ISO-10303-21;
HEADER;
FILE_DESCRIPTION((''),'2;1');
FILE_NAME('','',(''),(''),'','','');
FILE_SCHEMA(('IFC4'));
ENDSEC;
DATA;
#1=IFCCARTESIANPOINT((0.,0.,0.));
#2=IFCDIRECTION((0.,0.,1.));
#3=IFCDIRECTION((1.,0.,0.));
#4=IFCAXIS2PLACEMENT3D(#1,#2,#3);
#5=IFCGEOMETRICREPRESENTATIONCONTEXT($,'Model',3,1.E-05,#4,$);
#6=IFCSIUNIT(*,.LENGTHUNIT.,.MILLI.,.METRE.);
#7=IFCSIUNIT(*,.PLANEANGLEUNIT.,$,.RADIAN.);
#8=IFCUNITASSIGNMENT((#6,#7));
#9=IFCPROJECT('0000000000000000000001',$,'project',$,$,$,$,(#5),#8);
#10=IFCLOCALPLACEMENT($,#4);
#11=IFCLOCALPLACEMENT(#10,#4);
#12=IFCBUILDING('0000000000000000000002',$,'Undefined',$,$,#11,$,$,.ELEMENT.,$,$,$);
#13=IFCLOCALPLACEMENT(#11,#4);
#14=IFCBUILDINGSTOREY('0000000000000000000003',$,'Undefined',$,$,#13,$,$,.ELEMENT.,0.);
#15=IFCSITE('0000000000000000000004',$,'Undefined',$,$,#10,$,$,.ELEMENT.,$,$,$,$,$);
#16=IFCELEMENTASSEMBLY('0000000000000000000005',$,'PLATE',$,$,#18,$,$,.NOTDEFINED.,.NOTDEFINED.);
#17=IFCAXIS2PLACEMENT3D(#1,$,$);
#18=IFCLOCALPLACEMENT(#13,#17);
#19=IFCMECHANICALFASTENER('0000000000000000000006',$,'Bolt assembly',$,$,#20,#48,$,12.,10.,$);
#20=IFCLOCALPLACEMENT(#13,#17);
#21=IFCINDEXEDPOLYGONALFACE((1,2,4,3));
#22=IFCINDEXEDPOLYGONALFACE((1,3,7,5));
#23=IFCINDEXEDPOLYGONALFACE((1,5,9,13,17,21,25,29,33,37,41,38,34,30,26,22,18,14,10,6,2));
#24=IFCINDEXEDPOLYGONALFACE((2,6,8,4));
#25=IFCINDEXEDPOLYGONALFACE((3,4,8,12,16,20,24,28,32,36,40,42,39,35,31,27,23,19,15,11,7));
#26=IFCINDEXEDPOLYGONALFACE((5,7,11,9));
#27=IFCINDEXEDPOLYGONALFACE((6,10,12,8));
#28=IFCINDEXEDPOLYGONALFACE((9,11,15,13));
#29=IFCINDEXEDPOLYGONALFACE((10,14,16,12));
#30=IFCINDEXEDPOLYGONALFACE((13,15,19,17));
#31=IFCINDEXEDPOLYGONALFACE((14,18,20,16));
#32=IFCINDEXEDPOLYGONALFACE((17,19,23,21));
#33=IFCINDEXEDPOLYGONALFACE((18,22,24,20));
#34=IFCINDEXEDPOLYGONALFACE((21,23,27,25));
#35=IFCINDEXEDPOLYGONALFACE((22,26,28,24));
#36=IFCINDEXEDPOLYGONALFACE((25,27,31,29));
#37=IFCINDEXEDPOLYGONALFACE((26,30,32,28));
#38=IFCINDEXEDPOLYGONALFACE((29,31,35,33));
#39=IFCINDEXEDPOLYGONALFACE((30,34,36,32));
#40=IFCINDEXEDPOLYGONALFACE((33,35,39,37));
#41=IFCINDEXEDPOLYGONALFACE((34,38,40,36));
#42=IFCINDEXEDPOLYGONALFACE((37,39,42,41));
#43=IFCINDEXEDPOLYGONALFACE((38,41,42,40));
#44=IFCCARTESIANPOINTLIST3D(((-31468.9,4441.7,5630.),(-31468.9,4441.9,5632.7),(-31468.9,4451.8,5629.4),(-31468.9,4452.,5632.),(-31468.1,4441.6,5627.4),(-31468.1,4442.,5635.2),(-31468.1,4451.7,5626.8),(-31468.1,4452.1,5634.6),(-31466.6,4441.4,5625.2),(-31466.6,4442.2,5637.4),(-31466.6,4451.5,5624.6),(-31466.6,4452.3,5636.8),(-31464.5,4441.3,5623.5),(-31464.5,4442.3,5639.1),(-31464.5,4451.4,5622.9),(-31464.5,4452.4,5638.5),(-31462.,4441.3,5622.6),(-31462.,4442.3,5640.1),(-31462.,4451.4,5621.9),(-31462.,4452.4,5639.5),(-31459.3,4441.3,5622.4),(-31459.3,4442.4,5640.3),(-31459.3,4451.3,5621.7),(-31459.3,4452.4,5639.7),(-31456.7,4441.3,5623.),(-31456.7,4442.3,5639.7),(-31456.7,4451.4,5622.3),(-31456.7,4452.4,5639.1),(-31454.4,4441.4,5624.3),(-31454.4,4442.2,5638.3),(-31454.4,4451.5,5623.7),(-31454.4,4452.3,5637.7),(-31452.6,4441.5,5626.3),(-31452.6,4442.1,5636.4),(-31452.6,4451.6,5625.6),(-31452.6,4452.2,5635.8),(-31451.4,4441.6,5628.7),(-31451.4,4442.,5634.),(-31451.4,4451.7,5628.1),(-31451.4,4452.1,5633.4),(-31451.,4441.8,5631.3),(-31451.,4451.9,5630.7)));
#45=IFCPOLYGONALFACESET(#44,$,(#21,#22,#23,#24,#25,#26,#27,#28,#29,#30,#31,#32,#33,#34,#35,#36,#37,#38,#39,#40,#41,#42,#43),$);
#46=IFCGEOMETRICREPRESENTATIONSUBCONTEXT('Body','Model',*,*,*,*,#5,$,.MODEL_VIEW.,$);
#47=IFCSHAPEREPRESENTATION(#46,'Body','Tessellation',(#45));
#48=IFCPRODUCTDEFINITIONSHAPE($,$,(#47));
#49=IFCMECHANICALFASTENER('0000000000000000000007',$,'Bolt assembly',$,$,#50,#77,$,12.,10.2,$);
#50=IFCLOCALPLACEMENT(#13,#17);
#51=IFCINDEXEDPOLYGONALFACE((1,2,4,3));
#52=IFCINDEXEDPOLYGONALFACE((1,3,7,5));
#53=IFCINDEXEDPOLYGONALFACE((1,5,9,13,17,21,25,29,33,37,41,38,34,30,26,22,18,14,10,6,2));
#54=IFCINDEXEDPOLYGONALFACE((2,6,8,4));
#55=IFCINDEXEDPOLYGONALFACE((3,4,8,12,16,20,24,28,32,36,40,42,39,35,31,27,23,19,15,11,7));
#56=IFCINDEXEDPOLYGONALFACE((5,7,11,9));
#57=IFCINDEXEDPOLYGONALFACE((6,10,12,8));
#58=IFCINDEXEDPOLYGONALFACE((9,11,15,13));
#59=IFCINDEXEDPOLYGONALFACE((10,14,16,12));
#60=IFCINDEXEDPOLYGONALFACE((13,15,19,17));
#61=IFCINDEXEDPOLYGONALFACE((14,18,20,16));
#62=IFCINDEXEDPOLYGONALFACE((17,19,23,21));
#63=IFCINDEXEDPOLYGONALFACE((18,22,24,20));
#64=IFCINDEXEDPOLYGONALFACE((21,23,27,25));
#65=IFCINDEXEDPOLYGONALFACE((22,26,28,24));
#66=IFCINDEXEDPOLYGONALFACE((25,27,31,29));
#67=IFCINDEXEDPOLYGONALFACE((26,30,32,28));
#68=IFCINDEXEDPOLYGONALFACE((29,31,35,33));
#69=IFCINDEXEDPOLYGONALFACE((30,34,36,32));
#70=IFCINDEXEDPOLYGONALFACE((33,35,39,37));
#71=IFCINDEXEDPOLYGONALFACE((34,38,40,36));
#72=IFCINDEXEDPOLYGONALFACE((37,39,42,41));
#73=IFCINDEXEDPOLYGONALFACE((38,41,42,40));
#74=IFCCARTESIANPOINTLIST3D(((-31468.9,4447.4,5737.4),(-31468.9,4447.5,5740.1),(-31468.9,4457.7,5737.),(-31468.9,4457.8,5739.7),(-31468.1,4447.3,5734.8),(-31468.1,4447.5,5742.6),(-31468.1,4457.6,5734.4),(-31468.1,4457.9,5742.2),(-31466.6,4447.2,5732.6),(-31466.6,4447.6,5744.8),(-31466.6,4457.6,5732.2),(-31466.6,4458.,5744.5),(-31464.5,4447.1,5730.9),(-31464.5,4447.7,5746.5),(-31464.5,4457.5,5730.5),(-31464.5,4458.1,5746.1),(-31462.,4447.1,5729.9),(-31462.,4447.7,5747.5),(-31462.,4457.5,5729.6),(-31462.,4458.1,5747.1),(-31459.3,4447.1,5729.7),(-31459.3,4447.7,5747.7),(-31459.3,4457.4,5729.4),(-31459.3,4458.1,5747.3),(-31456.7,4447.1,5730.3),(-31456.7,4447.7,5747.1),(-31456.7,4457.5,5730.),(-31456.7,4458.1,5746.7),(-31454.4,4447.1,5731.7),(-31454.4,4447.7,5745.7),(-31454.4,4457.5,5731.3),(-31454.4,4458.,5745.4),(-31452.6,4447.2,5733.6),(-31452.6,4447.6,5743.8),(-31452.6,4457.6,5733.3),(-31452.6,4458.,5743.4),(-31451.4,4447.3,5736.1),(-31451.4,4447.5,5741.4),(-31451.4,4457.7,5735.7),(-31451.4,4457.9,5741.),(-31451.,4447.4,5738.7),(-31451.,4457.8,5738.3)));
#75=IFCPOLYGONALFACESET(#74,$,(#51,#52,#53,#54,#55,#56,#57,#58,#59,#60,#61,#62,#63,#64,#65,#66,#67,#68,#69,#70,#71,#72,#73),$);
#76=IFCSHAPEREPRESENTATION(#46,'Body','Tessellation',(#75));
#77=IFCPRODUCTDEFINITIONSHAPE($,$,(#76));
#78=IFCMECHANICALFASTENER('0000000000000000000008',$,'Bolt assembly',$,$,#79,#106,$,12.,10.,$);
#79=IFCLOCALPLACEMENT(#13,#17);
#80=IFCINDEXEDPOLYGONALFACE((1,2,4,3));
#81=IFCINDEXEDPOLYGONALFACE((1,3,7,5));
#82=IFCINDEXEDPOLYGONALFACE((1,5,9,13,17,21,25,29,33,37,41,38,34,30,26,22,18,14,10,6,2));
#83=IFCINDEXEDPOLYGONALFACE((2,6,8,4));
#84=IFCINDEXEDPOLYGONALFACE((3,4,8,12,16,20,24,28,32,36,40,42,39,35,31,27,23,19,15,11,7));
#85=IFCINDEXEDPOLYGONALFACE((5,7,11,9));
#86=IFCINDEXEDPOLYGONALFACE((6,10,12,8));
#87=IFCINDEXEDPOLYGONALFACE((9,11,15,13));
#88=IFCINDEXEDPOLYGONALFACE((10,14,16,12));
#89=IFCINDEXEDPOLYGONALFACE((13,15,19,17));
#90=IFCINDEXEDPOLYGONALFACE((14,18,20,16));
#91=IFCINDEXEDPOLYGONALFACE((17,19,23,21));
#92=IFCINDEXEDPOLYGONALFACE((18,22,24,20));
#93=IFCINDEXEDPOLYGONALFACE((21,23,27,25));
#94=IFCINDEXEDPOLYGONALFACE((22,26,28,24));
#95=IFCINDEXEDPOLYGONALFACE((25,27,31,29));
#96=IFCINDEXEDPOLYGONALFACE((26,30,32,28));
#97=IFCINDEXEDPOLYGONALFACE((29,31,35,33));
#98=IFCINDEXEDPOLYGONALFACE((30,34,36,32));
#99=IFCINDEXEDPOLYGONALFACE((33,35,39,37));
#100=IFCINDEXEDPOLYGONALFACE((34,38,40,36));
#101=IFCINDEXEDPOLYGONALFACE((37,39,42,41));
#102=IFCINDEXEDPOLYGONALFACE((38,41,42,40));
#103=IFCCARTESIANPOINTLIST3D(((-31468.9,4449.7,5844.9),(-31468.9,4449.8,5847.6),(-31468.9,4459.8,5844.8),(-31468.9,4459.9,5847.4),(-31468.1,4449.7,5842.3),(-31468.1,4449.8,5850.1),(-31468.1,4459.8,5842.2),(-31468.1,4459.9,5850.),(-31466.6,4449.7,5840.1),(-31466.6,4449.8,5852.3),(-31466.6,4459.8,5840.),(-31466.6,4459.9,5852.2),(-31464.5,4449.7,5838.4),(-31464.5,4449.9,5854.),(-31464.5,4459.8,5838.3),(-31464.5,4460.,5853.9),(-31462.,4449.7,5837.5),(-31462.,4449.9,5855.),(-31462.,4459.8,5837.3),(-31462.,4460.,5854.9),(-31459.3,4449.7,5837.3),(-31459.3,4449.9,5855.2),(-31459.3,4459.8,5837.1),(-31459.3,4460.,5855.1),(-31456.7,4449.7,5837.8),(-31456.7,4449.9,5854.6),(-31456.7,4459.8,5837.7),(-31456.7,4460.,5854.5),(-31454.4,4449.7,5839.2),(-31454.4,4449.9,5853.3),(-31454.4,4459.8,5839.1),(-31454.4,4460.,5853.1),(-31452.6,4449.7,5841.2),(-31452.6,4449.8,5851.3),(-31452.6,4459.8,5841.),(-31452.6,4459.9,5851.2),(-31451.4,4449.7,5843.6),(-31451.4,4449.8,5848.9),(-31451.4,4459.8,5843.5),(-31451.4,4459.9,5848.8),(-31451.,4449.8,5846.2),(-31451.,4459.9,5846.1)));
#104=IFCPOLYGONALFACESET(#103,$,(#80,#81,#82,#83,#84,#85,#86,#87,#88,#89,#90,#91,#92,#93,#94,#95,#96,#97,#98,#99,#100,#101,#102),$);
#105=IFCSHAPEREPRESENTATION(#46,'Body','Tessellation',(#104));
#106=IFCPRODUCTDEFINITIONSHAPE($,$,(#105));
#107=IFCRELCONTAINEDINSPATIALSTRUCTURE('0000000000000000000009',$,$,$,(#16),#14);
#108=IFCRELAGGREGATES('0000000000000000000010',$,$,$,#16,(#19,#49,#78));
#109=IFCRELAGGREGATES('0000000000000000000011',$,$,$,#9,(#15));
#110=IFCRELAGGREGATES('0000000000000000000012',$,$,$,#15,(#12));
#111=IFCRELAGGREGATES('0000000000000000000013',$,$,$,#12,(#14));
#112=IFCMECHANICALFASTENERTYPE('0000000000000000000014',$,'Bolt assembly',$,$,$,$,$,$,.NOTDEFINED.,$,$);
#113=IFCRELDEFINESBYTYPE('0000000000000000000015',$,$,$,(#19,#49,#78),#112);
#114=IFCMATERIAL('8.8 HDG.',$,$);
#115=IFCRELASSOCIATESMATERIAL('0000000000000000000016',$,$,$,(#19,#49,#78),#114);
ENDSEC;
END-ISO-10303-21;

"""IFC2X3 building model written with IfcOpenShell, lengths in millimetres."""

from ifc_helpers import new_model, si_unit, frame, origin_with_axes, origin_2d_with_axis, place, context, subcontext, project, spatial, circle, extrude, source, transform, mapped, material, type_object, element, aggregate, save


model = new_model("IFC2X3")

# Units and contexts
model_context = context("Model", 3, precision=1e-05, world=origin_with_axes())
body_context = subcontext(model_context, "Body", "Model", "MODEL_VIEW")
ifc_project = project(units=[si_unit("LENGTHUNIT", "METRE", prefix="MILLI"), si_unit("PLANEANGLEUNIT", "RADIAN")], contexts=[model_context])

# Site, building, storey
site_placement = place(None, origin_with_axes())
site = spatial("IfcSite", under=ifc_project, at=site_placement, Name="Undefined", CompositionType="ELEMENT")
building_placement = place(site_placement, origin_with_axes())
building = spatial("IfcBuilding", under=site, at=building_placement, Name="Undefined", CompositionType="ELEMENT")
storey_placement = place(building_placement, origin_with_axes())
storey = spatial("IfcBuildingStorey", under=building, at=storey_placement, Name="Undefined", CompositionType="ELEMENT", Elevation=0.0)

# Element assembly, mechanical fasteners
assembly_placement = place(storey_placement, origin_with_axes())
assembly = element("IfcElementAssembly", 1, at=assembly_placement, inside=storey, Name="PLATE", AssemblyPlace="NOTDEFINED", PredefinedType="NOTDEFINED")
ifc_material_1 = material(Name="8.8 HDG.")
mechanical_fastener_type = type_object("IfcMechanicalFastenerType", Name="Bolt assembly")
shared_shape_1 = source(origin_with_axes(), body_context, "Body", "SweptSolid", [
    extrude(circle(Radius=9.0, at=origin_2d_with_axis()), frame((0.0, 0.9, 0.0), z_axis=(0.0, 1.0, 0.0), x_axis=(1.0, 0.0, 0.0)), (0.0, 0.0, 1.0), 10.1),
])
mechanical_fastener_1_placement = place(assembly_placement, frame((-31460.0, 4452.8, 5630.7), z_axis=(0.000001, -0.060379, -0.998176), x_axis=(1.0, 0.000001, 0.000001)))
mechanical_fastener_1 = element("IfcMechanicalFastener", 2, at=mechanical_fastener_1_placement, type_object=mechanical_fastener_type, material=ifc_material_1, Name="Bolt assembly", NominalDiameter=12.0, NominalLength=10.0, context=body_context, shape_type="MappedRepresentation", body=[
    mapped(shared_shape_1, transform((0.0, 0.0, 0.0))),
])
shared_shape_2 = source(origin_with_axes(), body_context, "Body", "SweptSolid", [
    extrude(circle(Radius=9.0, at=origin_2d_with_axis()), frame((0.0, 0.2, 0.0), z_axis=(0.0, 1.0, 0.0), x_axis=(1.0, 0.0, 0.0)), (0.0, 0.0, 1.0), 10.4),
])
mechanical_fastener_2_placement = place(assembly_placement, frame((-31460.0, 4458.0, 5738.3), z_axis=(0.000001, -0.036241, -0.999343), x_axis=(1.0, 0.000001, 0.000001)))
mechanical_fastener_2 = element("IfcMechanicalFastener", 3, at=mechanical_fastener_2_placement, type_object=mechanical_fastener_type, material=ifc_material_1, Name="Bolt assembly", NominalDiameter=12.0, NominalLength=10.2, context=body_context, shape_type="MappedRepresentation", body=[
    mapped(shared_shape_2, transform((0.0, 0.0, 0.0))),
])
shared_shape_3 = source(origin_with_axes(), body_context, "Body", "SweptSolid", [
    extrude(circle(Radius=9.0, at=origin_2d_with_axis()), frame((0.0, 0.8, 0.0), z_axis=(0.0, 1.0, 0.0), x_axis=(1.0, 0.0, 0.0)), (0.0, 0.0, 1.0), 10.1),
])
mechanical_fastener_3_placement = place(assembly_placement, frame((-31460.0, 4460.6, 5846.1), z_axis=(0.000001, -0.012083, -0.999927), x_axis=(1.0, 0.000001, 0.000001)))
mechanical_fastener_3 = element("IfcMechanicalFastener", 4, at=mechanical_fastener_3_placement, type_object=mechanical_fastener_type, material=ifc_material_1, Name="Bolt assembly", NominalDiameter=12.0, NominalLength=10.0, context=body_context, shape_type="MappedRepresentation", body=[
    mapped(shared_shape_3, transform((0.0, 0.0, 0.0))),
])
aggregate(assembly, [mechanical_fastener_1, mechanical_fastener_2, mechanical_fastener_3])

save(model, "model.ifc")
